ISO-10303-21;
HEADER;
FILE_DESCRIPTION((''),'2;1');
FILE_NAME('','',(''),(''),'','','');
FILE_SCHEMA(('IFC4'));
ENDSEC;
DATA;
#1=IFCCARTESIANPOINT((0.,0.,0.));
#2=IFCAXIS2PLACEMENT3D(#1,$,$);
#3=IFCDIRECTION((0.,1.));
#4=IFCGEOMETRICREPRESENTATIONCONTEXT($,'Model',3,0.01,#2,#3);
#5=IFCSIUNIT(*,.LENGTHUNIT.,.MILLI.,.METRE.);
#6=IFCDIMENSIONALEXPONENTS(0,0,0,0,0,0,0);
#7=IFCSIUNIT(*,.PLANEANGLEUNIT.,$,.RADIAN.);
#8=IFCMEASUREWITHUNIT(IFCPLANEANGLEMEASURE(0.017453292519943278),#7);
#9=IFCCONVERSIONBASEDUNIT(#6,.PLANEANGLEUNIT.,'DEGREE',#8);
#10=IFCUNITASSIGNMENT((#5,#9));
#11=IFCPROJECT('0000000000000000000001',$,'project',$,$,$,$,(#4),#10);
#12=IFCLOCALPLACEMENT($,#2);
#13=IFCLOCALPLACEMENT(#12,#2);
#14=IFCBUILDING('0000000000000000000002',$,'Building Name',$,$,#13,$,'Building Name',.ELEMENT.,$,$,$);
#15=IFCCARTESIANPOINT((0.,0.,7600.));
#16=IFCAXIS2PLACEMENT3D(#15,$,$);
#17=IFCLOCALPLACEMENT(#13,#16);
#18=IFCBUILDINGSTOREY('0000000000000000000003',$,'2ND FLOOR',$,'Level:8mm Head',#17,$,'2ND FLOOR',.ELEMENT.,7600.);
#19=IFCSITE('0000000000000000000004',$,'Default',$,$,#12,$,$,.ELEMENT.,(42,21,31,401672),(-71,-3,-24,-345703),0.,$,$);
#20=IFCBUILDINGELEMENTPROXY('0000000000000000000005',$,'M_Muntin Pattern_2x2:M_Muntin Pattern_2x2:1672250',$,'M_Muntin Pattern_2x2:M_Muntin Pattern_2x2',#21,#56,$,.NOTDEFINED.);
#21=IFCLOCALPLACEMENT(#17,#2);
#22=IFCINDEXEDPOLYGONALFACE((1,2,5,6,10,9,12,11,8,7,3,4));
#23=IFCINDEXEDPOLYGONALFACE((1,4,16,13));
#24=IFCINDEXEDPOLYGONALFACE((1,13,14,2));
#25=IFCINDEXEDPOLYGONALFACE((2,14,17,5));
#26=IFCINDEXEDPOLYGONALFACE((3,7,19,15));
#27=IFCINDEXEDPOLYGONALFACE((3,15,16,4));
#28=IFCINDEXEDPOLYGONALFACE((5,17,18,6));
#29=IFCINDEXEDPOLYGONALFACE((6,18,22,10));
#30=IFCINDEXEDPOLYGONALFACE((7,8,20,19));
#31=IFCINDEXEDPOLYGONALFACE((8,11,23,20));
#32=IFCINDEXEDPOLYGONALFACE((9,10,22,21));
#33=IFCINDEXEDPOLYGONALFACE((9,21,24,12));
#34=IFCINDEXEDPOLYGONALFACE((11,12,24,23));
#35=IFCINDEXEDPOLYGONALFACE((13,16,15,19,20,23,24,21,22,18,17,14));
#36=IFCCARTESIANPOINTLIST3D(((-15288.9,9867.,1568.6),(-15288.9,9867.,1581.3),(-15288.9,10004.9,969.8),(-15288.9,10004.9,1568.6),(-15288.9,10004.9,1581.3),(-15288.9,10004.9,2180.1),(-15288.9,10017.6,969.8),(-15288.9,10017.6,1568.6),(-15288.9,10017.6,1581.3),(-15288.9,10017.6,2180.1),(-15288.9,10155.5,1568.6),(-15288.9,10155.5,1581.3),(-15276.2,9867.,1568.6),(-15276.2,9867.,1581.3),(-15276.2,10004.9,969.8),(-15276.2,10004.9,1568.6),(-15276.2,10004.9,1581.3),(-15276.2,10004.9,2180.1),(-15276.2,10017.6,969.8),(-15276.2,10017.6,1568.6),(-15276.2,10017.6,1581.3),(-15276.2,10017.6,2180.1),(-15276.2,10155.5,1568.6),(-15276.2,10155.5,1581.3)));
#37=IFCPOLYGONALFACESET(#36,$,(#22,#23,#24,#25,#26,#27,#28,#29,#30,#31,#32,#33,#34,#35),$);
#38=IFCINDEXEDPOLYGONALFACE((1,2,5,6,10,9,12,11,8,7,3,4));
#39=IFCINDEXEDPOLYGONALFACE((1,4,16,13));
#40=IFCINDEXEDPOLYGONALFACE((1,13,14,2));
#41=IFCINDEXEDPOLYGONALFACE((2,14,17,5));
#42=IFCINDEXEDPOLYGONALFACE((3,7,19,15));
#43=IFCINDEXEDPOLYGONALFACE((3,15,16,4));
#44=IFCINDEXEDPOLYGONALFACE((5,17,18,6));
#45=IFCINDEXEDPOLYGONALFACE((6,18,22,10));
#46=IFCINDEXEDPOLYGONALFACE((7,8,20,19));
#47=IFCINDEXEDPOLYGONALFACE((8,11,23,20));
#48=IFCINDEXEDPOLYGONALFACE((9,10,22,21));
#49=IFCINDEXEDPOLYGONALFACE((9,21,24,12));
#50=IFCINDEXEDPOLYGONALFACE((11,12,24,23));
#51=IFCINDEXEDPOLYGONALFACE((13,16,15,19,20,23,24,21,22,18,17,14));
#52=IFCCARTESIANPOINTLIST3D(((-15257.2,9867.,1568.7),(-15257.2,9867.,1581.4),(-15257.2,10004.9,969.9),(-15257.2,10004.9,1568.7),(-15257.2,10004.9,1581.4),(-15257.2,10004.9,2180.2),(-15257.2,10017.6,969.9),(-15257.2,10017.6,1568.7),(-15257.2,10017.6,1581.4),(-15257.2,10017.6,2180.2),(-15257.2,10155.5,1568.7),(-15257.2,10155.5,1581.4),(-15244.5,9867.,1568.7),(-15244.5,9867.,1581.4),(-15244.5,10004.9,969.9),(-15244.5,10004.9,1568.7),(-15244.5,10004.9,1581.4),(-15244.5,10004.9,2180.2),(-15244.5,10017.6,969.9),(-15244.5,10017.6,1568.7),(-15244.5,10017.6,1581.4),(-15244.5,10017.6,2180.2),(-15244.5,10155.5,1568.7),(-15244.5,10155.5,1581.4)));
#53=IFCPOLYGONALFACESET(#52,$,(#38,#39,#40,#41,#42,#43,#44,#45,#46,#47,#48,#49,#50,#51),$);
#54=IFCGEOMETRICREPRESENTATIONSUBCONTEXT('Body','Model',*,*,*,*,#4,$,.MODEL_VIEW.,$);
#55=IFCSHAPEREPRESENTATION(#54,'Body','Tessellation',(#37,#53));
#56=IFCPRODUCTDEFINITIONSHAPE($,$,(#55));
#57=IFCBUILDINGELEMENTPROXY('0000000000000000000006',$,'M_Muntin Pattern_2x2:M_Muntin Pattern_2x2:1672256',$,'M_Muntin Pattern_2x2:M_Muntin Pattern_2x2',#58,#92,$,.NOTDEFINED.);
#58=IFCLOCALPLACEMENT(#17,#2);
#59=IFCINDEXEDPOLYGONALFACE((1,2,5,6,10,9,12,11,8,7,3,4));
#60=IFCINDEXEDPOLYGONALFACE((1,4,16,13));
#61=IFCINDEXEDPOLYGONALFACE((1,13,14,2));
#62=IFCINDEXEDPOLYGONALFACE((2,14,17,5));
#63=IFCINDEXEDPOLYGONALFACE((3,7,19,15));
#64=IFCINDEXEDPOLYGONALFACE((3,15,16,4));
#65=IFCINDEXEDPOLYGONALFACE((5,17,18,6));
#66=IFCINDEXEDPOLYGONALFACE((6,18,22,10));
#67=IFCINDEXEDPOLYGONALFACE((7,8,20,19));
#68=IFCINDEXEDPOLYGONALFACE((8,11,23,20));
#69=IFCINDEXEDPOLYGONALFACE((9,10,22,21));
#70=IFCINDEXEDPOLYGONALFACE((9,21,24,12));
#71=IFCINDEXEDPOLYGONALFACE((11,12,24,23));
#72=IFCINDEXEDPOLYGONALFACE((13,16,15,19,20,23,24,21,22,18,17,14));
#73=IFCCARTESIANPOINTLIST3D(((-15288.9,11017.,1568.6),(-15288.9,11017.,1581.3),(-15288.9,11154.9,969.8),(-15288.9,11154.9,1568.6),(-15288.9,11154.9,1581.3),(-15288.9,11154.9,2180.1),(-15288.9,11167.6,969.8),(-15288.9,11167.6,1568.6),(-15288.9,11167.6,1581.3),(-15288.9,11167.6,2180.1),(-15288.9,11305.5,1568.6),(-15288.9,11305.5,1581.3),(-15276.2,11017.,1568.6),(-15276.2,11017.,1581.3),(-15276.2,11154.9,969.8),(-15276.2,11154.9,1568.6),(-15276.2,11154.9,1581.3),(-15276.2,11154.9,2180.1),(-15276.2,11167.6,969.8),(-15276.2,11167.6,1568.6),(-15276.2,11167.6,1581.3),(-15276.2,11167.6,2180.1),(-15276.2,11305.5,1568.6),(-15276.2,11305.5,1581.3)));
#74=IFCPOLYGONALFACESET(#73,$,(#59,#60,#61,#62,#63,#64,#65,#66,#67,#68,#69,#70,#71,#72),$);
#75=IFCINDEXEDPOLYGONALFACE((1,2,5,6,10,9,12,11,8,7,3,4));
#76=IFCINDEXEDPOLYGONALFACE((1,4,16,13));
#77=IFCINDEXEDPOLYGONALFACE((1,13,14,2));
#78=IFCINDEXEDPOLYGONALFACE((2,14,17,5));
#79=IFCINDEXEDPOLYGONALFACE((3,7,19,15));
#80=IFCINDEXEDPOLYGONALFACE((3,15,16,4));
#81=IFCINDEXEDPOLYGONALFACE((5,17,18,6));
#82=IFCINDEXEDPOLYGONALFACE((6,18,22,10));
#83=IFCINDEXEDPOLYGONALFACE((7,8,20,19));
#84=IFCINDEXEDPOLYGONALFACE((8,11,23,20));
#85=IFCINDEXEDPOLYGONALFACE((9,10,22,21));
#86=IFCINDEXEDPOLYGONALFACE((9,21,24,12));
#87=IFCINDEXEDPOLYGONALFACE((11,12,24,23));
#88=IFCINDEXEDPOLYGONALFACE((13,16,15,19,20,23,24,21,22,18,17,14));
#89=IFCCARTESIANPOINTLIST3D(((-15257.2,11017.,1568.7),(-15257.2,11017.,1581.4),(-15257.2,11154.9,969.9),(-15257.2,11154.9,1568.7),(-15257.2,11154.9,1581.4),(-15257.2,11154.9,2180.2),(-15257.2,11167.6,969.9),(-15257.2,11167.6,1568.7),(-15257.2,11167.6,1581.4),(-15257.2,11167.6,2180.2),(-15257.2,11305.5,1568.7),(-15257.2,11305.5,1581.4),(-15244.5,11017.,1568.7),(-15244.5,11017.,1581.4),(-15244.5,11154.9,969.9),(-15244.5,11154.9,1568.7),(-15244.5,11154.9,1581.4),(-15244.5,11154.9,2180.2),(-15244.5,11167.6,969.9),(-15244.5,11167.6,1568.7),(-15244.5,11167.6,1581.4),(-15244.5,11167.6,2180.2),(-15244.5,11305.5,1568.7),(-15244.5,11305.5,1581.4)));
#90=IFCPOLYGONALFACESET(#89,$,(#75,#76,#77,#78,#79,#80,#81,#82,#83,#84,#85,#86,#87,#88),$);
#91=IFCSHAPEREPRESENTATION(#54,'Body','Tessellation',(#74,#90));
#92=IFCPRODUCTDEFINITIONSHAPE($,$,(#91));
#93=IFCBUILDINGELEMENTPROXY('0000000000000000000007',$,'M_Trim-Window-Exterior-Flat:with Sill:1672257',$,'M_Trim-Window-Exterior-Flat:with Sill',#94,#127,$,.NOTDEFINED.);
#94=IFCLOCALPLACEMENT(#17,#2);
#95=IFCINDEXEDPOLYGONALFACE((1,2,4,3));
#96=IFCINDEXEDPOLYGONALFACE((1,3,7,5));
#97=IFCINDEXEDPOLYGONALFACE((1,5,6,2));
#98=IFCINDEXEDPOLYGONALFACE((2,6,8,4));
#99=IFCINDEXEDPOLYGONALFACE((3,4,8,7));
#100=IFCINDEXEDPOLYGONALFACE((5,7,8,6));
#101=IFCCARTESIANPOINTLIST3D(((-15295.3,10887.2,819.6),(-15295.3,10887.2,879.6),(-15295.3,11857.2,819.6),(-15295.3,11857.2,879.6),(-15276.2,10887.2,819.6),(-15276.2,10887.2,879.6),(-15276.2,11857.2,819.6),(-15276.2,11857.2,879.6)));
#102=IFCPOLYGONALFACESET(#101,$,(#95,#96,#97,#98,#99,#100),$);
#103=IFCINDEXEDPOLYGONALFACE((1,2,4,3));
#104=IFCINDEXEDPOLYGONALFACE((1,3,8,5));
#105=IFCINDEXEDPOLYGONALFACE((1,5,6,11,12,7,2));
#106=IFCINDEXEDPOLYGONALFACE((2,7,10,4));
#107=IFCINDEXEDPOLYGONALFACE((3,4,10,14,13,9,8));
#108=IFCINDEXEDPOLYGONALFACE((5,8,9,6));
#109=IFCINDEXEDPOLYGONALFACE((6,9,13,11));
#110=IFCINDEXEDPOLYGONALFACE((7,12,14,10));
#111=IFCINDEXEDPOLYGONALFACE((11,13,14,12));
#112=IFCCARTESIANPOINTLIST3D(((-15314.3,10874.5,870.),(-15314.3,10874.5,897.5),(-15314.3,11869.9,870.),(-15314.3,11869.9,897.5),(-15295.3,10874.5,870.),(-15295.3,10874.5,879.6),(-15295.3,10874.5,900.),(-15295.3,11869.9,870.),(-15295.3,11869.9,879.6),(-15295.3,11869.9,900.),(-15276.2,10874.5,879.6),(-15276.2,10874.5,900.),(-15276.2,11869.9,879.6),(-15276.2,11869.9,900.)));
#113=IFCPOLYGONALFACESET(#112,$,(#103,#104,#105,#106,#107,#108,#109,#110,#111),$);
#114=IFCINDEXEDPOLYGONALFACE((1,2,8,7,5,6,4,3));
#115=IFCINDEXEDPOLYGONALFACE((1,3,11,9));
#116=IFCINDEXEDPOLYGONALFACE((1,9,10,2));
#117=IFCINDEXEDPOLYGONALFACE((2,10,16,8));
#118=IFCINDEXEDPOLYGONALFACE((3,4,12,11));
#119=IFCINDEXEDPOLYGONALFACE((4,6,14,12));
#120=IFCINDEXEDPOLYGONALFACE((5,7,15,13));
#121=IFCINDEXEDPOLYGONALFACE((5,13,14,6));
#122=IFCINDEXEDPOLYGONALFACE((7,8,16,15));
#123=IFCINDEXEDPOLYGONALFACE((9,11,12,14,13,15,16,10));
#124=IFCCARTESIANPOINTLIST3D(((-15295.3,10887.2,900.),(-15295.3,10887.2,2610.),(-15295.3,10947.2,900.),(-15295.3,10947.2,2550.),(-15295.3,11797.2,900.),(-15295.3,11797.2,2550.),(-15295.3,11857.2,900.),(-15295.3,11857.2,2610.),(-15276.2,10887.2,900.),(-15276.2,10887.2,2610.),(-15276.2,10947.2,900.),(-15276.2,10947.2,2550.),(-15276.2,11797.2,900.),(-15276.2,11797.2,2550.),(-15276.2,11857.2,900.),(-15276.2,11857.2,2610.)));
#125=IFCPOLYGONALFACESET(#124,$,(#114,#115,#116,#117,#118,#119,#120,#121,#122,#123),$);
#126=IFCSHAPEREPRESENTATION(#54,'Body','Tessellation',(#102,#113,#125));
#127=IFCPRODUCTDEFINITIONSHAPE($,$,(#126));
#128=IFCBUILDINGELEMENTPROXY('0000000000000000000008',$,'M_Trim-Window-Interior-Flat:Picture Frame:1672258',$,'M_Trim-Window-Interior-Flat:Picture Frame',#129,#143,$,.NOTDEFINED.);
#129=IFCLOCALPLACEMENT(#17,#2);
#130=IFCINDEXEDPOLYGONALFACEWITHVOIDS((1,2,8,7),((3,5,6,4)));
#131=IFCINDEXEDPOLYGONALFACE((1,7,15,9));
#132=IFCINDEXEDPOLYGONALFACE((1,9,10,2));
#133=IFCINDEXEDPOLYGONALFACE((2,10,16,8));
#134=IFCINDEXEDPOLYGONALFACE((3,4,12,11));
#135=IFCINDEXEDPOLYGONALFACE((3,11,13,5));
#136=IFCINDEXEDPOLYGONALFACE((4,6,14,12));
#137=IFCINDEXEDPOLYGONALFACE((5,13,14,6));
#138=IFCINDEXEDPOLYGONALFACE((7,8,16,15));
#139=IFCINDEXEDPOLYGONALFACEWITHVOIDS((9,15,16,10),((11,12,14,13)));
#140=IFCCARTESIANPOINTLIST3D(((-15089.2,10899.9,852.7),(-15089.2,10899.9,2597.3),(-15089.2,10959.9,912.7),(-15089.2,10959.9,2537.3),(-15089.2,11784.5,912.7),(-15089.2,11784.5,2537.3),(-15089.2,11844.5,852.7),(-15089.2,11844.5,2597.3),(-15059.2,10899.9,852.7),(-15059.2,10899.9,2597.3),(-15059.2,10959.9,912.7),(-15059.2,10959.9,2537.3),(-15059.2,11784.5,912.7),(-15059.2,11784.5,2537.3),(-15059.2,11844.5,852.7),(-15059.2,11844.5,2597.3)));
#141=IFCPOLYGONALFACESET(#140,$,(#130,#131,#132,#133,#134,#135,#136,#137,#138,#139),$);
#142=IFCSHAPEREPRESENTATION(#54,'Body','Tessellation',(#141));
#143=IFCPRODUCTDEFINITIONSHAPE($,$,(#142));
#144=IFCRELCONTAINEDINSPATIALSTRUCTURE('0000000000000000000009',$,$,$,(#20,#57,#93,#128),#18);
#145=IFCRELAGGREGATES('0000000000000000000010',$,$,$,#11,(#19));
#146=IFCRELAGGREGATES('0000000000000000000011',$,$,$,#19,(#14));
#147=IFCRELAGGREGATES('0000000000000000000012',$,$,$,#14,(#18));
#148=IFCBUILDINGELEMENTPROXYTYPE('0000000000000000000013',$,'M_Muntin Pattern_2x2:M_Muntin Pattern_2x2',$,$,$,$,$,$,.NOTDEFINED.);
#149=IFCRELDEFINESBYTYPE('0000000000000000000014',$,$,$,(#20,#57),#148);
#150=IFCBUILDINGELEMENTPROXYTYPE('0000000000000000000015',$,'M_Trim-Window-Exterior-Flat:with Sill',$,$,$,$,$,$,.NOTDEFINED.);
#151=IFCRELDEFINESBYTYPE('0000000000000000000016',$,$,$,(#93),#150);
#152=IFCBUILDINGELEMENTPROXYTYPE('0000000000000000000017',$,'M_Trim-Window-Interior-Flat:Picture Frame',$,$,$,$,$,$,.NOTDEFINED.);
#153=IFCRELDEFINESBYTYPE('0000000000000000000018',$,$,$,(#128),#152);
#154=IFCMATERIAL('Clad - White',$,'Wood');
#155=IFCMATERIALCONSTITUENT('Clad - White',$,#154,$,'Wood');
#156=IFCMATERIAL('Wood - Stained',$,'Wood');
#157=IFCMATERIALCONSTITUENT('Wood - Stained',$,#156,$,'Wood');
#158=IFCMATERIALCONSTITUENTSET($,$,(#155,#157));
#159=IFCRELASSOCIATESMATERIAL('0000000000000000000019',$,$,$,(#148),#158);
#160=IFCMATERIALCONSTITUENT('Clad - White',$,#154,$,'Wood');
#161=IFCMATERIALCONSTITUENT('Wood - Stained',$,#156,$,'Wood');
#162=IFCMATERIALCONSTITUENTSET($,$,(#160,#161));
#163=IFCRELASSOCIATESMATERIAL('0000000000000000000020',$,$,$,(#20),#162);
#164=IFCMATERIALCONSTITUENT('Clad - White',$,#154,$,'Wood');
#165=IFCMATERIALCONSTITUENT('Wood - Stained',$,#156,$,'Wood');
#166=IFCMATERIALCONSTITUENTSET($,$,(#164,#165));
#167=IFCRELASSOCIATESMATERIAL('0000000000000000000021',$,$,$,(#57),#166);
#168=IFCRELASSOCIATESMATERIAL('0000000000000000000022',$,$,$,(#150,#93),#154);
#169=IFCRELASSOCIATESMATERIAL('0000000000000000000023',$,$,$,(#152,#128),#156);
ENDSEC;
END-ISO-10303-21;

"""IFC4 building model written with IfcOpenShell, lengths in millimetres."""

from ifc_helpers import new_model, entity, si_unit, converted_unit, direction, frame, origin, place, context, subcontext, project, spatial, indexed_curve, outline, extrude, source, transform, mapped, material, constituent, constituent_set, type_object, type_shapes, element, save


model = new_model("IFC4")

# Units and contexts
model_context = context("Model", 3, precision=0.01, world=origin(), true_north=direction((0.0, 1.0)))
body_context = subcontext(model_context, "Body", "Model", "MODEL_VIEW")
ifc_project = project(units=[si_unit("LENGTHUNIT", "METRE", prefix="MILLI"), converted_unit("PLANEANGLEUNIT", "DEGREE", entity("IfcPlaneAngleMeasure", 0.017453292519943278), si_unit("PLANEANGLEUNIT", "RADIAN"), dimensions=[0, 0, 0, 0, 0, 0, 0])], contexts=[model_context])

# Site, building, storey
site_placement = place(None, origin())
site = spatial("IfcSite", under=ifc_project, at=site_placement, Name="Default", CompositionType="ELEMENT", RefLatitude=(42, 21, 31, 401672), RefLongitude=(-71, -3, -24, -345703), RefElevation=0.0)
building_placement = place(site_placement, origin())
building = spatial("IfcBuilding", under=site, at=building_placement, Name="Building Name", LongName="Building Name", CompositionType="ELEMENT")
storey_placement = place(building_placement, frame((0.0, 0.0, 7600.0)))
storey = spatial("IfcBuildingStorey", under=building, at=storey_placement, Name="2ND FLOOR", ObjectType="Level:8mm Head", LongName="2ND FLOOR", CompositionType="ELEMENT", Elevation=7600.0)

# Shared definitions
ifc_material_1 = material(Name="Wood - Stained", Category="Wood")

# Building element proxies
ifc_material_2 = material(Name="Clad - White", Category="Wood")
ifc_constituent_1 = constituent(ifc_material_2, Name="Clad - White", Category="Wood")
ifc_constituent_2 = constituent(ifc_material_1, Name="Wood - Stained", Category="Wood")
ifc_constituent_set_1 = constituent_set(constituents=[ifc_constituent_1, ifc_constituent_2])
ifc_constituent_3 = constituent(ifc_material_2, Name="Clad - White", Category="Wood")
ifc_constituent_4 = constituent(ifc_material_1, Name="Wood - Stained", Category="Wood")
ifc_constituent_set_2 = constituent_set(constituents=[ifc_constituent_3, ifc_constituent_4])
building_element_proxy_type_1 = type_object("IfcBuildingElementProxyType", Name="M_Muntin Pattern_2x2:M_Muntin Pattern_2x2", PredefinedType="NOTDEFINED", material=ifc_constituent_set_2)
shared_shape_1 = source(origin(), body_context, "Body", "SweptSolid", [
    extrude(outline(indexed_curve([(6.4, -6.4), (605.1, -6.4), (605.1, 6.3), (6.4, 6.3), (6.4, 144.2), (-6.3, 144.2), (-6.3, 6.3), (-605.2, 6.3), (-605.2, -6.4), (-6.3, -6.4), (-6.3, -144.2), (6.4, -144.2), (6.4, -6.4)], self_intersect=False)), frame((0.0, 9.5, 605.1), z_axis=(0.0, 1.0, 0.0), x_axis=(0.0, 0.0, 1.0)), (0.0, 0.0, 1.0), 12.7),
    extrude(outline(indexed_curve([(6.4, -6.4), (605.2, -6.4), (605.2, 6.3), (6.4, 6.3), (6.4, 144.2), (-6.3, 144.2), (-6.3, 6.3), (-605.2, 6.3), (-605.2, -6.4), (-6.3, -6.4), (-6.3, -144.2), (6.4, -144.2), (6.4, -6.4)], self_intersect=False)), frame((0.0, -22.2, 605.2), z_axis=(0.0, 1.0, 0.0), x_axis=(0.0, 0.0, 1.0)), (0.0, 0.0, 1.0), 12.7),
])
type_shapes(building_element_proxy_type_1, [shared_shape_1])
proxy_1_placement = place(storey_placement, frame((-15266.7, 10011.3, 969.9), z_axis=(0.0, 0.0, 1.0), x_axis=(0.0, 1.0, 0.0)))
element("IfcBuildingElementProxy", 1, at=proxy_1_placement, inside=storey, type_object=building_element_proxy_type_1, material=ifc_constituent_set_1, Name="M_Muntin Pattern_2x2:M_Muntin Pattern_2x2:1672250", ObjectType="M_Muntin Pattern_2x2:M_Muntin Pattern_2x2", PredefinedType="NOTDEFINED", context=body_context, shape_type="MappedRepresentation", body=[
    mapped(shared_shape_1, transform((0.0, 0.0, 0.0), scale=1.0)),
])
ifc_constituent_5 = constituent(ifc_material_2, Name="Clad - White", Category="Wood")
ifc_constituent_6 = constituent(ifc_material_1, Name="Wood - Stained", Category="Wood")
ifc_constituent_set_3 = constituent_set(constituents=[ifc_constituent_5, ifc_constituent_6])
proxy_2_placement = place(storey_placement, frame((-15266.7, 11161.3, 969.9), z_axis=(0.0, 0.0, 1.0), x_axis=(0.0, 1.0, 0.0)))
element("IfcBuildingElementProxy", 2, at=proxy_2_placement, inside=storey, type_object=building_element_proxy_type_1, material=ifc_constituent_set_3, Name="M_Muntin Pattern_2x2:M_Muntin Pattern_2x2:1672256", ObjectType="M_Muntin Pattern_2x2:M_Muntin Pattern_2x2", PredefinedType="NOTDEFINED", context=body_context, shape_type="MappedRepresentation", body=[
    mapped(shared_shape_1, transform((0.0, 0.0, 0.0), scale=1.0)),
])
building_element_proxy_type_2 = type_object("IfcBuildingElementProxyType", Name="M_Trim-Window-Exterior-Flat:with Sill", PredefinedType="NOTDEFINED", material=ifc_material_2)
shared_shape_2 = source(origin(), body_context, "Body", "SweptSolid", [
    extrude(outline(indexed_curve([(-30.0, -485.0), (30.0, -485.0), (30.0, 485.0), (-30.0, 485.0), (-30.0, -485.0)], self_intersect=False)), frame((0.0, 1700.4, 0.0), z_axis=(0.0, 0.0, 1.0), x_axis=(0.0, 1.0, 0.0)), (0.0, 0.0, 1.0), 19.0),
    extrude(outline(indexed_curve([(-15.2, -19.0), (12.3, -19.0), (14.8, 0.0), (14.8, 19.0), (-5.7, 19.0), (-5.7, 0.0), (-15.2, 0.0), (-15.2, -19.0)], self_intersect=False)), frame((-497.7, 1664.8, 19.0), z_axis=(1.0, 0.0, 0.0), x_axis=(0.0, -1.0, 0.0)), (0.0, 0.0, 1.0), 995.4),
    extrude(outline(indexed_curve([(-485.0, -870.0), (485.0, -870.0), (485.0, 840.0), (425.0, 840.0), (425.0, -810.0), (-425.0, -810.0), (-425.0, 840.0), (-485.0, 840.0), (-485.0, -870.0)], self_intersect=False)), frame((0.0, 810.0, 0.0)), (0.0, 0.0, 1.0), 19.0),
])
type_shapes(building_element_proxy_type_2, [shared_shape_2])
proxy_3_placement = place(storey_placement, frame((-15276.2, 11372.2, 2550.0), z_axis=(-1.0, 0.0, 0.0), x_axis=(0.0, 1.0, 0.0)))
element("IfcBuildingElementProxy", 3, at=proxy_3_placement, inside=storey, type_object=building_element_proxy_type_2, material=ifc_material_2, Name="M_Trim-Window-Exterior-Flat:with Sill:1672257", ObjectType="M_Trim-Window-Exterior-Flat:with Sill", PredefinedType="NOTDEFINED", context=body_context, shape_type="MappedRepresentation", body=[
    mapped(shared_shape_2, transform((0.0, 0.0, 0.0), scale=1.0)),
])
building_element_proxy_type_3 = type_object("IfcBuildingElementProxyType", Name="M_Trim-Window-Interior-Flat:Picture Frame", PredefinedType="NOTDEFINED", material=ifc_material_1)
shared_shape_3 = source(origin(), body_context, "Body", "SweptSolid", [
    extrude(outline(indexed_curve([(-872.3, -472.3), (872.3, -472.3), (872.3, 472.3), (-872.3, 472.3), (-872.3, -472.3)], self_intersect=False), holes=[indexed_curve([(-812.3, -412.3), (-812.3, 412.3), (812.3, 412.3), (812.3, -412.3), (-812.3, -412.3)], self_intersect=False)]), frame((0.0, 825.0, 0.0), z_axis=(0.0, 0.0, 1.0), x_axis=(0.0, 1.0, 0.0)), (0.0, 0.0, 1.0), 30.0),
])
type_shapes(building_element_proxy_type_3, [shared_shape_3])
proxy_4_placement = place(storey_placement, frame((-15089.2, 11372.2, 2550.0), z_axis=(1.0, 0.0, 0.0), x_axis=(0.0, -1.0, 0.0)))
element("IfcBuildingElementProxy", 4, at=proxy_4_placement, inside=storey, type_object=building_element_proxy_type_3, material=ifc_material_1, Name="M_Trim-Window-Interior-Flat:Picture Frame:1672258", ObjectType="M_Trim-Window-Interior-Flat:Picture Frame", PredefinedType="NOTDEFINED", context=body_context, shape_type="MappedRepresentation", body=[
    mapped(shared_shape_3, transform((0.0, 0.0, 0.0), scale=1.0)),
])

save(model, "model.ifc")
